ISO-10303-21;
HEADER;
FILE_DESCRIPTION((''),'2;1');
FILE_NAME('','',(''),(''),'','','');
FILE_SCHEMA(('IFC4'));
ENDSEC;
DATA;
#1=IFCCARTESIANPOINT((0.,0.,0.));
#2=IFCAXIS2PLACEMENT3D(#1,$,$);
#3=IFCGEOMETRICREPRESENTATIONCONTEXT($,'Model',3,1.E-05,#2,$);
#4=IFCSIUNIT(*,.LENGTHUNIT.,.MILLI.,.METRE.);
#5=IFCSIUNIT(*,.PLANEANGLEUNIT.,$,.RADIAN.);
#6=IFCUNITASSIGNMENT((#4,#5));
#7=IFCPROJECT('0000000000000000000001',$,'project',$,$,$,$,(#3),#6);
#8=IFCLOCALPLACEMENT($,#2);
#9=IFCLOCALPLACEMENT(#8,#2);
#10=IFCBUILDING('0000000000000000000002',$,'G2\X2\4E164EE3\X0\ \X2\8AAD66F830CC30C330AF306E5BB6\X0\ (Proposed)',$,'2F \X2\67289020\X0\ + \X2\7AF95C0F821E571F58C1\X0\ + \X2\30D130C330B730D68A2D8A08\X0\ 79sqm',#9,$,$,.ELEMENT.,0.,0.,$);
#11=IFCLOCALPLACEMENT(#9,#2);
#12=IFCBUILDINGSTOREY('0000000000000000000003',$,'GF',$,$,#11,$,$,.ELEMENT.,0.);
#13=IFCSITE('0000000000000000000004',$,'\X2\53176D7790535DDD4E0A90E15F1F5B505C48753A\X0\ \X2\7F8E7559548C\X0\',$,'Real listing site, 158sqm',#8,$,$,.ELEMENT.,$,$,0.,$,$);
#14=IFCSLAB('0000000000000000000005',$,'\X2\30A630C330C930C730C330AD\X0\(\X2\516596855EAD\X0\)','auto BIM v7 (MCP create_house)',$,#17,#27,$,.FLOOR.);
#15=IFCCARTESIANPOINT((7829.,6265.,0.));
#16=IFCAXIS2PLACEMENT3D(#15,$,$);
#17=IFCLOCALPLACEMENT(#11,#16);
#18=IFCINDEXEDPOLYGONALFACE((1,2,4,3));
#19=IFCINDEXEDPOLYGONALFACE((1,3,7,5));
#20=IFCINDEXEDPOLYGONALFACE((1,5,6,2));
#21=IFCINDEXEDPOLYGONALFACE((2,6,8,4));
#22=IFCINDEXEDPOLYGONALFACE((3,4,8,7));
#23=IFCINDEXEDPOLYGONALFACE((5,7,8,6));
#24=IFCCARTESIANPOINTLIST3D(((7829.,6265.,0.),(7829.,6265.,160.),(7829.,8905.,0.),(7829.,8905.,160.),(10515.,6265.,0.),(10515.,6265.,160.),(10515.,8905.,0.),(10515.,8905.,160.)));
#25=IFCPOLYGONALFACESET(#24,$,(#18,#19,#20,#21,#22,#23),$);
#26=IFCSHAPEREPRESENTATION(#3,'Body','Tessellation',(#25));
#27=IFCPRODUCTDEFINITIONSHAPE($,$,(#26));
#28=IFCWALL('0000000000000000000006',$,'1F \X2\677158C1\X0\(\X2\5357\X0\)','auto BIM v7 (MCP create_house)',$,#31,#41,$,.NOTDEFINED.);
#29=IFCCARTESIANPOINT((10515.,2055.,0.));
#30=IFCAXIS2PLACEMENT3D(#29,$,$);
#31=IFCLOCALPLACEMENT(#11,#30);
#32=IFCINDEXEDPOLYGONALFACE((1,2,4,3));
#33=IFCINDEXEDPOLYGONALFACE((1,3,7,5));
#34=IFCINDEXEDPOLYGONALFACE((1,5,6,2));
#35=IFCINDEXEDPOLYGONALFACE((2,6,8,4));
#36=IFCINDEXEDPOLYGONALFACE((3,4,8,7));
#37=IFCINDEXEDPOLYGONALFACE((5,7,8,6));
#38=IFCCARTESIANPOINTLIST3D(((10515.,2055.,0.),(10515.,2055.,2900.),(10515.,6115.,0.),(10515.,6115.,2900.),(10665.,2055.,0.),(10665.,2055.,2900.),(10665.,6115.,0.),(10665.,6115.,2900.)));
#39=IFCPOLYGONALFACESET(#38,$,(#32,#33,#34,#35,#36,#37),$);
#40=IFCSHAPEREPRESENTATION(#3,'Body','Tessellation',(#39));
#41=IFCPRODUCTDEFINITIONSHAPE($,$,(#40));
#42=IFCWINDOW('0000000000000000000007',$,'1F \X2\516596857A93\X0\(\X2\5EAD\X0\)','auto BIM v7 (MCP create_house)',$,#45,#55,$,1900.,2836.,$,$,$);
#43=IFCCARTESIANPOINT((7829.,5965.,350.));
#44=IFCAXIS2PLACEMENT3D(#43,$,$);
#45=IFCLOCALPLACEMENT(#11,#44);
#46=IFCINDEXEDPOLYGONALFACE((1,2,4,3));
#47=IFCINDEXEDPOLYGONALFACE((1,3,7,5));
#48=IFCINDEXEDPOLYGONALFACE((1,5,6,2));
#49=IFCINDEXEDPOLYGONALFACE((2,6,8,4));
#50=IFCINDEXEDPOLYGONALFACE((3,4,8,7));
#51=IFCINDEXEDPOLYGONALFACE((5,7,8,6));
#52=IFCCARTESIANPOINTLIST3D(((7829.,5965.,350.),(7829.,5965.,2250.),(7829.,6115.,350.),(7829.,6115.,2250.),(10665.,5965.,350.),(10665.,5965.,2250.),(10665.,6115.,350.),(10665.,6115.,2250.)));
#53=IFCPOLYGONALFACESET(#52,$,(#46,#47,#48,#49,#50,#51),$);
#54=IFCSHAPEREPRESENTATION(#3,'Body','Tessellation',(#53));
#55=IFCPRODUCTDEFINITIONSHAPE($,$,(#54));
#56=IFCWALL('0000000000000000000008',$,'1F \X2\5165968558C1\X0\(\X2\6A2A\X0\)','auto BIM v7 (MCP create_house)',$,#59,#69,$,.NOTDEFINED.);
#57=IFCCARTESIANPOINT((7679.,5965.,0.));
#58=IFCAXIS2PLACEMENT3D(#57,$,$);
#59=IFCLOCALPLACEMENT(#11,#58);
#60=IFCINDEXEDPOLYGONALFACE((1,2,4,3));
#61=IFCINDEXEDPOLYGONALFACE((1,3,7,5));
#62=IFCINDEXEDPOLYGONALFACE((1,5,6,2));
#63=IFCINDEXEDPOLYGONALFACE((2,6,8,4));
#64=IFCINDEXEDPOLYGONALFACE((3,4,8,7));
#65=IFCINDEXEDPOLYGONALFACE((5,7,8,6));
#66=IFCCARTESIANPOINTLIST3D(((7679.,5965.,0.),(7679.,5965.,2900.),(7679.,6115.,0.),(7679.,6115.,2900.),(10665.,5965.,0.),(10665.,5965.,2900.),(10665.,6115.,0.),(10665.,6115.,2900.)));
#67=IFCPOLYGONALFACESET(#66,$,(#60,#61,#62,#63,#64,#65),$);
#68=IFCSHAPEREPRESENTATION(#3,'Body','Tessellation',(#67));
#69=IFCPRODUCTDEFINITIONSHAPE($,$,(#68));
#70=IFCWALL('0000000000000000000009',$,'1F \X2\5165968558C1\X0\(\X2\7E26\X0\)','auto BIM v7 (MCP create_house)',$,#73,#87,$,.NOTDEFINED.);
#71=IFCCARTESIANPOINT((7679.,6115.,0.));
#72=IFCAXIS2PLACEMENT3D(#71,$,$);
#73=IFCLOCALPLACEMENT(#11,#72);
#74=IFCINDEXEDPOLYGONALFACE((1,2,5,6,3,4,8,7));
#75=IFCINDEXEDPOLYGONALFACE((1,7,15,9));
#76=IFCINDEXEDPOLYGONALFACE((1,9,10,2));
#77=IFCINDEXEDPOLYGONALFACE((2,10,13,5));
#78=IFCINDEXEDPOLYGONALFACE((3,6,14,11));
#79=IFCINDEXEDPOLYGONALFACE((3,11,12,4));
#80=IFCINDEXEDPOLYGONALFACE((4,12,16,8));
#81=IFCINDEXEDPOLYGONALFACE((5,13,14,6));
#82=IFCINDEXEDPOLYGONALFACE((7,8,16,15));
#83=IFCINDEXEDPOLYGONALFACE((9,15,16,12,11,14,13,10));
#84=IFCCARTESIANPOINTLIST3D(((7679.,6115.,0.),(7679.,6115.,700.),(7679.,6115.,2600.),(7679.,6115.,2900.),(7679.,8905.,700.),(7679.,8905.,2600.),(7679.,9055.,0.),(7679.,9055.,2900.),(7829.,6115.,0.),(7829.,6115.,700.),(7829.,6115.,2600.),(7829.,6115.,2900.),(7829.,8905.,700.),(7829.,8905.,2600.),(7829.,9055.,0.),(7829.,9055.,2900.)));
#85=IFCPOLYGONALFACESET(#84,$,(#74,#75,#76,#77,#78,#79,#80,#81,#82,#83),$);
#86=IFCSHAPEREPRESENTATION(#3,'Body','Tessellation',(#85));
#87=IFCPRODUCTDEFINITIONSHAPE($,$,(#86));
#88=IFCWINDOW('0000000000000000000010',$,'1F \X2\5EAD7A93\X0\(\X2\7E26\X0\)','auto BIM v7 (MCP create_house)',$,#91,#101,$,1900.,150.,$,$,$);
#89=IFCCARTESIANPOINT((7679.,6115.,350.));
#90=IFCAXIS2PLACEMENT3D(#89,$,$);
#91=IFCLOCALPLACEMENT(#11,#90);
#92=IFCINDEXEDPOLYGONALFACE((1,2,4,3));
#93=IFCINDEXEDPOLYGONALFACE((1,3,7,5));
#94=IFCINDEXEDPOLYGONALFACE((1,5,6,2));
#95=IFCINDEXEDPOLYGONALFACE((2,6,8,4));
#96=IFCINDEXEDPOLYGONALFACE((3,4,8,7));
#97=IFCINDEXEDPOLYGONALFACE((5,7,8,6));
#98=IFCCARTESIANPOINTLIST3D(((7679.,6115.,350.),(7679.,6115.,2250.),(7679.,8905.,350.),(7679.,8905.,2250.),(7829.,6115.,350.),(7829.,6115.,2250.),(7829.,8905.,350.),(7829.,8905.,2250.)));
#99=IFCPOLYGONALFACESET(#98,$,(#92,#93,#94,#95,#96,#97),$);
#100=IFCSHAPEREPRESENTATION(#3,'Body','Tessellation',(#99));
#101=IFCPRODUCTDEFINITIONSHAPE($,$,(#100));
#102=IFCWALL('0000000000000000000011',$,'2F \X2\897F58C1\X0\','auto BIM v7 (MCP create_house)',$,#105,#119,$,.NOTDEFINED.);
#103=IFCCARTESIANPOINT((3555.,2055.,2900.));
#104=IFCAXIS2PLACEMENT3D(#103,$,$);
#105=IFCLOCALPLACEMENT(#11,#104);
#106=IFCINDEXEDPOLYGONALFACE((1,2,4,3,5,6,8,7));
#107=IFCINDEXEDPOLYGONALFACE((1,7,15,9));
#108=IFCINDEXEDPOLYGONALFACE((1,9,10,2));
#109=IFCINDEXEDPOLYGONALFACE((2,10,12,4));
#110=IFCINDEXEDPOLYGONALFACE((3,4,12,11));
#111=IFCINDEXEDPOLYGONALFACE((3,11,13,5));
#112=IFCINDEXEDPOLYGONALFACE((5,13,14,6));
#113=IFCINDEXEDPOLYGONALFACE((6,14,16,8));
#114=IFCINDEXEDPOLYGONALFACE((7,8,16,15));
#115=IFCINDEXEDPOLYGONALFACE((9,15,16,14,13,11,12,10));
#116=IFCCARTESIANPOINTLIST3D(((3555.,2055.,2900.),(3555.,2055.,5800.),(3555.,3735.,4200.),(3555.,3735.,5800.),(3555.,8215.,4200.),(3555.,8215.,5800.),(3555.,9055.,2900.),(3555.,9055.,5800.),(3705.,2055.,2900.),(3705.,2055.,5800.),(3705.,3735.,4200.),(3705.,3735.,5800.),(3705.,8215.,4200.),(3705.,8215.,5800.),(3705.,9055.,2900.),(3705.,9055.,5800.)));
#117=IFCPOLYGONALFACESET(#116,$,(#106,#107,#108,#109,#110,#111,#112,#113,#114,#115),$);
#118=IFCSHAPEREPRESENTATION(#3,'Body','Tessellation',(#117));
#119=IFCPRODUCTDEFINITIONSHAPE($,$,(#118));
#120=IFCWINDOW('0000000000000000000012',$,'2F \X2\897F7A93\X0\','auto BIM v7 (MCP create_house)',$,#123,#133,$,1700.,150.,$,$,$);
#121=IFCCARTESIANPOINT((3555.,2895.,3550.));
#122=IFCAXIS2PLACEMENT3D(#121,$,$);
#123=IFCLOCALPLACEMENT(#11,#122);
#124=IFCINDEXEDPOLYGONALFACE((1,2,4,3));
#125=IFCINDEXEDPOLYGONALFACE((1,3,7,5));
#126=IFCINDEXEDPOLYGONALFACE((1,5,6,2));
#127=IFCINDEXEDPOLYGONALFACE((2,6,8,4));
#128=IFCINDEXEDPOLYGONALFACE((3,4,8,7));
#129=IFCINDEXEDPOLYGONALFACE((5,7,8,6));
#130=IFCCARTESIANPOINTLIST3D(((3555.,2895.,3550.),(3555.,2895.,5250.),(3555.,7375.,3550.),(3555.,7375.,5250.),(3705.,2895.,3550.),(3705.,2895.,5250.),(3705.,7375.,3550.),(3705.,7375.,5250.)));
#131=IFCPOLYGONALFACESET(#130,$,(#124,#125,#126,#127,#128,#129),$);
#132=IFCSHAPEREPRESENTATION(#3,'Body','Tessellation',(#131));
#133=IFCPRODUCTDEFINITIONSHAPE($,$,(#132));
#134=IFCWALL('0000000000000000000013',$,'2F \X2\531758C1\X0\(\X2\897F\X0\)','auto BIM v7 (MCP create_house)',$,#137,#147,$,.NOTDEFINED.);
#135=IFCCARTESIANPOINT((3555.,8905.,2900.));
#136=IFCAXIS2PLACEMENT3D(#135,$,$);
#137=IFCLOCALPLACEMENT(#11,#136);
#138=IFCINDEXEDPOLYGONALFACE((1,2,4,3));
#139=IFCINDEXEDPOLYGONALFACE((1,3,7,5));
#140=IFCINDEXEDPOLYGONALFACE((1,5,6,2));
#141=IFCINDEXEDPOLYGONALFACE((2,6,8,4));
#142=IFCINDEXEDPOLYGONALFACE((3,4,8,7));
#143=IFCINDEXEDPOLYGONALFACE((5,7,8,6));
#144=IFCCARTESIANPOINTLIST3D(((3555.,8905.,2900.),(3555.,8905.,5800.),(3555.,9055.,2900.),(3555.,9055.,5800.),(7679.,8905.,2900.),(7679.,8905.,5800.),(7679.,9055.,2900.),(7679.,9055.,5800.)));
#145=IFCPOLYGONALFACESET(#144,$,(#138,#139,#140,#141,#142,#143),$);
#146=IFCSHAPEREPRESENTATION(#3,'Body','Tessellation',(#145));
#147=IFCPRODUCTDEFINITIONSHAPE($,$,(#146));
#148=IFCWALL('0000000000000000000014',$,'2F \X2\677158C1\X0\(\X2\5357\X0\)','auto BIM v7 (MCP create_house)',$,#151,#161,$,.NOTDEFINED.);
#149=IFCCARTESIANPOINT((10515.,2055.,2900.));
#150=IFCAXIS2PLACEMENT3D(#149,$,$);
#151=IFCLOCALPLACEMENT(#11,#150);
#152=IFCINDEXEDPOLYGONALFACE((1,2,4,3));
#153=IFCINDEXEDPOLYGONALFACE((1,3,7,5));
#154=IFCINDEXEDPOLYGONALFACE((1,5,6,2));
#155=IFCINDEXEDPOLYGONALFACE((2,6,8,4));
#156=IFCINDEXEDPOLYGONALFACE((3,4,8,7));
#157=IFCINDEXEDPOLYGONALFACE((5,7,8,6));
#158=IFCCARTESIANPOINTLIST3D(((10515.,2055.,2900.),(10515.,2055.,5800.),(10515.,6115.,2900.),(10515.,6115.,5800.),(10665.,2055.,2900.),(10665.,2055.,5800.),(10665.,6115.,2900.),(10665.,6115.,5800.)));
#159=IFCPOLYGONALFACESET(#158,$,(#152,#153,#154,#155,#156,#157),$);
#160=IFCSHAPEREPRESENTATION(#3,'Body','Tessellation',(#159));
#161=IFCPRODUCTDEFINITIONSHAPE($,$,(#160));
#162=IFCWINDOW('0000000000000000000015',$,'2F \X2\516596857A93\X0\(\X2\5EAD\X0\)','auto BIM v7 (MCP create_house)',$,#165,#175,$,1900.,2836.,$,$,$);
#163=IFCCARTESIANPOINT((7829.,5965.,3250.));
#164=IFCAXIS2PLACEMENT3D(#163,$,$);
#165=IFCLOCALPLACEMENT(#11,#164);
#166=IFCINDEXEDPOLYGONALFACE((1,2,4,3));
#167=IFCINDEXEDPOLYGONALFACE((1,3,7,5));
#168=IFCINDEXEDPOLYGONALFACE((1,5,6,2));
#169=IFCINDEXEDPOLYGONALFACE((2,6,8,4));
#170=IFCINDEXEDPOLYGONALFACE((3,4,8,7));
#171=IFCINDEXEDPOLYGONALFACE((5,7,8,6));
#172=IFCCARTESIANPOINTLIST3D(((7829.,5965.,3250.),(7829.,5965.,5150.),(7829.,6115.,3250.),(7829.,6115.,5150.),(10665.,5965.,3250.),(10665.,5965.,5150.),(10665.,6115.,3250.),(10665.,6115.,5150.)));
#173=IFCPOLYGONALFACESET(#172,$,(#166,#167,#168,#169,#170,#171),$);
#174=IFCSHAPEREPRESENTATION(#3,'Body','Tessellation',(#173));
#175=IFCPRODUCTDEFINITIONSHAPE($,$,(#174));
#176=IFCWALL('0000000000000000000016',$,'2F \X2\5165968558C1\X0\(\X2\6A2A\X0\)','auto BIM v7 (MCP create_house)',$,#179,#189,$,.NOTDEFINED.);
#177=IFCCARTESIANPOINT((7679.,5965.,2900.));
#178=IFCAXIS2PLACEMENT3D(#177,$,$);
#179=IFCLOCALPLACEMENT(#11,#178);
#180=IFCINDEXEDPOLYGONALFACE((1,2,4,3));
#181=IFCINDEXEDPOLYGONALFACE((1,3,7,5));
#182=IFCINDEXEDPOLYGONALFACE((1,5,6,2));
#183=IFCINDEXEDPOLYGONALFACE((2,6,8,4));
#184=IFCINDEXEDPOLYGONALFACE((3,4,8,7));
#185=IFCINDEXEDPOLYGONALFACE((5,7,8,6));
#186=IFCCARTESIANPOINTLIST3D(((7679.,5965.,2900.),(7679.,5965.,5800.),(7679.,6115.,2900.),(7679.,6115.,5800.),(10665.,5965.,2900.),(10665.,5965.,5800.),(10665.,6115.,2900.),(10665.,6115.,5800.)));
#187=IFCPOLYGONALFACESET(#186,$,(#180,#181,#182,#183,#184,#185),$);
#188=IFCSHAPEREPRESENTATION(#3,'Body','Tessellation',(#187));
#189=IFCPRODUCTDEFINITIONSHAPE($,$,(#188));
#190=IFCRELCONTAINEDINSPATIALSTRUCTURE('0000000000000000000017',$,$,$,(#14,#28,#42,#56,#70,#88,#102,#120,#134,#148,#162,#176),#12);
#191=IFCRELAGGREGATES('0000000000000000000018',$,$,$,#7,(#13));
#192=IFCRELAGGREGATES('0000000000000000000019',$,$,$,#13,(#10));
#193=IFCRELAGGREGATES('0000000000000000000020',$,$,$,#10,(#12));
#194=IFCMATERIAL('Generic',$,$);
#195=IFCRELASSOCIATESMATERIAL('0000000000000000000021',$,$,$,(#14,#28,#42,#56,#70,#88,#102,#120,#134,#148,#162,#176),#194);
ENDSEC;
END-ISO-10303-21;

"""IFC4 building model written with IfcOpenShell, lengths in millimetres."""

from ifc_helpers import new_model, si_unit, frame, frame_2d, origin, place, context, project, spatial, rectangle, extrude, material, element, fill, save


model = new_model("IFC4")

# Units and contexts
model_context = context("Model", 3, precision=1e-05, world=origin())
ifc_project = project(units=[si_unit("LENGTHUNIT", "METRE", prefix="MILLI"), si_unit("PLANEANGLEUNIT", "RADIAN")], contexts=[model_context])

# Site, building, storey
site_placement = place(None, origin())
site = spatial("IfcSite", under=ifc_project, at=site_placement, Name="北海道川上郡弟子屈町 美留和", ObjectType="Real listing site, 158sqm", CompositionType="ELEMENT", RefElevation=0.0)
building_placement = place(site_placement, origin())
building = spatial("IfcBuilding", under=site, at=building_placement, Name="G2世代 読書ヌックの家 (Proposed)", ObjectType="2F 木造 + 竹小舞土壁 + パッシブ設計 79sqm", CompositionType="ELEMENT", ElevationOfRefHeight=0.0, ElevationOfTerrain=0.0)
storey_placement = place(building_placement, origin())
storey = spatial("IfcBuildingStorey", under=building, at=storey_placement, Name="GF", CompositionType="ELEMENT", Elevation=0.0)

# Slab
ifc_material = material(Name="Generic")
slab_placement = place(storey_placement, frame((7829.0, 6265.0, 0.0)))
element("IfcSlab", 1, at=slab_placement, inside=storey, material=ifc_material, Name="ウッドデッキ(入隅庭)", Description="auto BIM v7 (MCP create_house)", PredefinedType="FLOOR", context=model_context, shape_type="SweptSolid", body=[
    extrude(rectangle(XDim=2686.0, YDim=2640.0, at=frame_2d((1343.0, 1320.0))), frame((7829.0, 6265.0, 0.0)), (0.0, 0.0, 1.0), 160.0),
])

# Wall, opening, window
wall_1_placement = place(storey_placement, frame((10515.0, 2055.0, 0.0)))
wall_1 = element("IfcWall", 2, at=wall_1_placement, inside=storey, material=ifc_material, Name="1F 東壁(南)", Description="auto BIM v7 (MCP create_house)", PredefinedType="NOTDEFINED", context=model_context, shape_type="SweptSolid", body=[
    extrude(rectangle(XDim=150.0, YDim=4060.0, at=frame_2d((75.0, 2030.0))), frame((10515.0, 2055.0, 0.0)), (0.0, 0.0, 1.0), 2900.0),
])
opening_1_placement = place(storey_placement, frame((7829.0, 5965.0, 350.0)))
opening_1 = element("IfcOpeningElement", 3, at=opening_1_placement, cuts=wall_1, PredefinedType="NOTDEFINED", context=model_context, shape_type="SweptSolid", body=[
    extrude(rectangle(XDim=2836.0, YDim=150.0, at=frame_2d((1418.0, 75.0))), frame((7829.0, 5965.0, 350.0)), (0.0, 0.0, 1.0), 1900.0),
])
window_1_placement = place(storey_placement, frame((7829.0, 5965.0, 350.0)))
window_1 = element("IfcWindow", 4, at=window_1_placement, inside=storey, material=ifc_material, Name="1F 入隅窓(庭)", Description="auto BIM v7 (MCP create_house)", OverallHeight=1900.0, OverallWidth=2836.0, context=model_context, shape_type="SweptSolid", body=[
    extrude(rectangle(XDim=2836.0, YDim=150.0, at=frame_2d((1418.0, 75.0))), frame((7829.0, 5965.0, 350.0)), (0.0, 0.0, 1.0), 1900.0),
])
fill(opening_1, window_1)

# Wall
wall_2_placement = place(storey_placement, frame((7679.0, 5965.0, 0.0)))
element("IfcWall", 5, at=wall_2_placement, inside=storey, material=ifc_material, Name="1F 入隅壁(横)", Description="auto BIM v7 (MCP create_house)", PredefinedType="NOTDEFINED", context=model_context, shape_type="SweptSolid", body=[
    extrude(rectangle(XDim=2986.0, YDim=150.0, at=frame_2d((1493.0, 75.0))), frame((7679.0, 5965.0, 0.0)), (0.0, 0.0, 1.0), 2900.0),
])

# Wall, opening, window
wall_3_placement = place(storey_placement, frame((7679.0, 6115.0, 0.0)))
wall_3 = element("IfcWall", 6, at=wall_3_placement, inside=storey, material=ifc_material, Name="1F 入隅壁(縦)", Description="auto BIM v7 (MCP create_house)", PredefinedType="NOTDEFINED", context=model_context, shape_type="SweptSolid", body=[
    extrude(rectangle(XDim=150.0, YDim=2940.0, at=frame_2d((75.0, 1470.0))), frame((7679.0, 6115.0, 0.0)), (0.0, 0.0, 1.0), 2900.0),
])
opening_2_placement = place(storey_placement, frame((7679.0, 6115.0, 350.0)))
opening_2 = element("IfcOpeningElement", 7, at=opening_2_placement, cuts=wall_3, PredefinedType="NOTDEFINED", context=model_context, shape_type="SweptSolid", body=[
    extrude(rectangle(XDim=150.0, YDim=2790.0, at=frame_2d((75.0, 1395.0))), frame((7679.0, 6115.0, 350.0)), (0.0, 0.0, 1.0), 1900.0),
])
window_2_placement = place(storey_placement, frame((7679.0, 6115.0, 350.0)))
window_2 = element("IfcWindow", 8, at=window_2_placement, inside=storey, material=ifc_material, Name="1F 庭窓(縦)", Description="auto BIM v7 (MCP create_house)", OverallHeight=1900.0, OverallWidth=150.0, context=model_context, shape_type="SweptSolid", body=[
    extrude(rectangle(XDim=150.0, YDim=2790.0, at=frame_2d((75.0, 1395.0))), frame((7679.0, 6115.0, 350.0)), (0.0, 0.0, 1.0), 1900.0),
])
fill(opening_2, window_2)

# Wall, opening, window
wall_4_placement = place(storey_placement, frame((3555.0, 2055.0, 2900.0)))
wall_4 = element("IfcWall", 9, at=wall_4_placement, inside=storey, material=ifc_material, Name="2F 西壁", Description="auto BIM v7 (MCP create_house)", PredefinedType="NOTDEFINED", context=model_context, shape_type="SweptSolid", body=[
    extrude(rectangle(XDim=150.0, YDim=7000.0, at=frame_2d((75.0, 3500.0))), frame((3555.0, 2055.0, 2900.0)), (0.0, 0.0, 1.0), 2900.0),
])
opening_3_placement = place(storey_placement, frame((3555.0, 2895.0, 3550.0)))
opening_3 = element("IfcOpeningElement", 10, at=opening_3_placement, cuts=wall_4, PredefinedType="NOTDEFINED", context=model_context, shape_type="SweptSolid", body=[
    extrude(rectangle(XDim=150.0, YDim=4480.0, at=frame_2d((75.0, 2240.0))), frame((3555.0, 2895.0, 3550.0)), (0.0, 0.0, 1.0), 1700.0),
])
window_3_placement = place(storey_placement, frame((3555.0, 2895.0, 3550.0)))
window_3 = element("IfcWindow", 11, at=window_3_placement, inside=storey, material=ifc_material, Name="2F 西窓", Description="auto BIM v7 (MCP create_house)", OverallHeight=1700.0, OverallWidth=150.0, context=model_context, shape_type="SweptSolid", body=[
    extrude(rectangle(XDim=150.0, YDim=4480.0, at=frame_2d((75.0, 2240.0))), frame((3555.0, 2895.0, 3550.0)), (0.0, 0.0, 1.0), 1700.0),
])
fill(opening_3, window_3)

# Wall
wall_5_placement = place(storey_placement, frame((3555.0, 8905.0, 2900.0)))
element("IfcWall", 12, at=wall_5_placement, inside=storey, material=ifc_material, Name="2F 北壁(西)", Description="auto BIM v7 (MCP create_house)", PredefinedType="NOTDEFINED", context=model_context, shape_type="SweptSolid", body=[
    extrude(rectangle(XDim=4124.0, YDim=150.0, at=frame_2d((2062.0, 75.0))), frame((3555.0, 8905.0, 2900.0)), (0.0, 0.0, 1.0), 2900.0),
])

# Wall, opening, window
wall_6_placement = place(storey_placement, frame((10515.0, 2055.0, 2900.0)))
wall_6 = element("IfcWall", 13, at=wall_6_placement, inside=storey, material=ifc_material, Name="2F 東壁(南)", Description="auto BIM v7 (MCP create_house)", PredefinedType="NOTDEFINED", context=model_context, shape_type="SweptSolid", body=[
    extrude(rectangle(XDim=150.0, YDim=4060.0, at=frame_2d((75.0, 2030.0))), frame((10515.0, 2055.0, 2900.0)), (0.0, 0.0, 1.0), 2900.0),
])
opening_4_placement = place(storey_placement, frame((7829.0, 5965.0, 3250.0)))
opening_4 = element("IfcOpeningElement", 14, at=opening_4_placement, cuts=wall_6, PredefinedType="NOTDEFINED", context=model_context, shape_type="SweptSolid", body=[
    extrude(rectangle(XDim=2836.0, YDim=150.0, at=frame_2d((1418.0, 75.0))), frame((7829.0, 5965.0, 3250.0)), (0.0, 0.0, 1.0), 1900.0),
])
window_4_placement = place(storey_placement, frame((7829.0, 5965.0, 3250.0)))
window_4 = element("IfcWindow", 15, at=window_4_placement, inside=storey, material=ifc_material, Name="2F 入隅窓(庭)", Description="auto BIM v7 (MCP create_house)", OverallHeight=1900.0, OverallWidth=2836.0, context=model_context, shape_type="SweptSolid", body=[
    extrude(rectangle(XDim=2836.0, YDim=150.0, at=frame_2d((1418.0, 75.0))), frame((7829.0, 5965.0, 3250.0)), (0.0, 0.0, 1.0), 1900.0),
])
fill(opening_4, window_4)

# Wall
wall_7_placement = place(storey_placement, frame((7679.0, 5965.0, 2900.0)))
element("IfcWall", 16, at=wall_7_placement, inside=storey, material=ifc_material, Name="2F 入隅壁(横)", Description="auto BIM v7 (MCP create_house)", PredefinedType="NOTDEFINED", context=model_context, shape_type="SweptSolid", body=[
    extrude(rectangle(XDim=2986.0, YDim=150.0, at=frame_2d((1493.0, 75.0))), frame((7679.0, 5965.0, 2900.0)), (0.0, 0.0, 1.0), 2900.0),
])

save(model, "model.ifc")
